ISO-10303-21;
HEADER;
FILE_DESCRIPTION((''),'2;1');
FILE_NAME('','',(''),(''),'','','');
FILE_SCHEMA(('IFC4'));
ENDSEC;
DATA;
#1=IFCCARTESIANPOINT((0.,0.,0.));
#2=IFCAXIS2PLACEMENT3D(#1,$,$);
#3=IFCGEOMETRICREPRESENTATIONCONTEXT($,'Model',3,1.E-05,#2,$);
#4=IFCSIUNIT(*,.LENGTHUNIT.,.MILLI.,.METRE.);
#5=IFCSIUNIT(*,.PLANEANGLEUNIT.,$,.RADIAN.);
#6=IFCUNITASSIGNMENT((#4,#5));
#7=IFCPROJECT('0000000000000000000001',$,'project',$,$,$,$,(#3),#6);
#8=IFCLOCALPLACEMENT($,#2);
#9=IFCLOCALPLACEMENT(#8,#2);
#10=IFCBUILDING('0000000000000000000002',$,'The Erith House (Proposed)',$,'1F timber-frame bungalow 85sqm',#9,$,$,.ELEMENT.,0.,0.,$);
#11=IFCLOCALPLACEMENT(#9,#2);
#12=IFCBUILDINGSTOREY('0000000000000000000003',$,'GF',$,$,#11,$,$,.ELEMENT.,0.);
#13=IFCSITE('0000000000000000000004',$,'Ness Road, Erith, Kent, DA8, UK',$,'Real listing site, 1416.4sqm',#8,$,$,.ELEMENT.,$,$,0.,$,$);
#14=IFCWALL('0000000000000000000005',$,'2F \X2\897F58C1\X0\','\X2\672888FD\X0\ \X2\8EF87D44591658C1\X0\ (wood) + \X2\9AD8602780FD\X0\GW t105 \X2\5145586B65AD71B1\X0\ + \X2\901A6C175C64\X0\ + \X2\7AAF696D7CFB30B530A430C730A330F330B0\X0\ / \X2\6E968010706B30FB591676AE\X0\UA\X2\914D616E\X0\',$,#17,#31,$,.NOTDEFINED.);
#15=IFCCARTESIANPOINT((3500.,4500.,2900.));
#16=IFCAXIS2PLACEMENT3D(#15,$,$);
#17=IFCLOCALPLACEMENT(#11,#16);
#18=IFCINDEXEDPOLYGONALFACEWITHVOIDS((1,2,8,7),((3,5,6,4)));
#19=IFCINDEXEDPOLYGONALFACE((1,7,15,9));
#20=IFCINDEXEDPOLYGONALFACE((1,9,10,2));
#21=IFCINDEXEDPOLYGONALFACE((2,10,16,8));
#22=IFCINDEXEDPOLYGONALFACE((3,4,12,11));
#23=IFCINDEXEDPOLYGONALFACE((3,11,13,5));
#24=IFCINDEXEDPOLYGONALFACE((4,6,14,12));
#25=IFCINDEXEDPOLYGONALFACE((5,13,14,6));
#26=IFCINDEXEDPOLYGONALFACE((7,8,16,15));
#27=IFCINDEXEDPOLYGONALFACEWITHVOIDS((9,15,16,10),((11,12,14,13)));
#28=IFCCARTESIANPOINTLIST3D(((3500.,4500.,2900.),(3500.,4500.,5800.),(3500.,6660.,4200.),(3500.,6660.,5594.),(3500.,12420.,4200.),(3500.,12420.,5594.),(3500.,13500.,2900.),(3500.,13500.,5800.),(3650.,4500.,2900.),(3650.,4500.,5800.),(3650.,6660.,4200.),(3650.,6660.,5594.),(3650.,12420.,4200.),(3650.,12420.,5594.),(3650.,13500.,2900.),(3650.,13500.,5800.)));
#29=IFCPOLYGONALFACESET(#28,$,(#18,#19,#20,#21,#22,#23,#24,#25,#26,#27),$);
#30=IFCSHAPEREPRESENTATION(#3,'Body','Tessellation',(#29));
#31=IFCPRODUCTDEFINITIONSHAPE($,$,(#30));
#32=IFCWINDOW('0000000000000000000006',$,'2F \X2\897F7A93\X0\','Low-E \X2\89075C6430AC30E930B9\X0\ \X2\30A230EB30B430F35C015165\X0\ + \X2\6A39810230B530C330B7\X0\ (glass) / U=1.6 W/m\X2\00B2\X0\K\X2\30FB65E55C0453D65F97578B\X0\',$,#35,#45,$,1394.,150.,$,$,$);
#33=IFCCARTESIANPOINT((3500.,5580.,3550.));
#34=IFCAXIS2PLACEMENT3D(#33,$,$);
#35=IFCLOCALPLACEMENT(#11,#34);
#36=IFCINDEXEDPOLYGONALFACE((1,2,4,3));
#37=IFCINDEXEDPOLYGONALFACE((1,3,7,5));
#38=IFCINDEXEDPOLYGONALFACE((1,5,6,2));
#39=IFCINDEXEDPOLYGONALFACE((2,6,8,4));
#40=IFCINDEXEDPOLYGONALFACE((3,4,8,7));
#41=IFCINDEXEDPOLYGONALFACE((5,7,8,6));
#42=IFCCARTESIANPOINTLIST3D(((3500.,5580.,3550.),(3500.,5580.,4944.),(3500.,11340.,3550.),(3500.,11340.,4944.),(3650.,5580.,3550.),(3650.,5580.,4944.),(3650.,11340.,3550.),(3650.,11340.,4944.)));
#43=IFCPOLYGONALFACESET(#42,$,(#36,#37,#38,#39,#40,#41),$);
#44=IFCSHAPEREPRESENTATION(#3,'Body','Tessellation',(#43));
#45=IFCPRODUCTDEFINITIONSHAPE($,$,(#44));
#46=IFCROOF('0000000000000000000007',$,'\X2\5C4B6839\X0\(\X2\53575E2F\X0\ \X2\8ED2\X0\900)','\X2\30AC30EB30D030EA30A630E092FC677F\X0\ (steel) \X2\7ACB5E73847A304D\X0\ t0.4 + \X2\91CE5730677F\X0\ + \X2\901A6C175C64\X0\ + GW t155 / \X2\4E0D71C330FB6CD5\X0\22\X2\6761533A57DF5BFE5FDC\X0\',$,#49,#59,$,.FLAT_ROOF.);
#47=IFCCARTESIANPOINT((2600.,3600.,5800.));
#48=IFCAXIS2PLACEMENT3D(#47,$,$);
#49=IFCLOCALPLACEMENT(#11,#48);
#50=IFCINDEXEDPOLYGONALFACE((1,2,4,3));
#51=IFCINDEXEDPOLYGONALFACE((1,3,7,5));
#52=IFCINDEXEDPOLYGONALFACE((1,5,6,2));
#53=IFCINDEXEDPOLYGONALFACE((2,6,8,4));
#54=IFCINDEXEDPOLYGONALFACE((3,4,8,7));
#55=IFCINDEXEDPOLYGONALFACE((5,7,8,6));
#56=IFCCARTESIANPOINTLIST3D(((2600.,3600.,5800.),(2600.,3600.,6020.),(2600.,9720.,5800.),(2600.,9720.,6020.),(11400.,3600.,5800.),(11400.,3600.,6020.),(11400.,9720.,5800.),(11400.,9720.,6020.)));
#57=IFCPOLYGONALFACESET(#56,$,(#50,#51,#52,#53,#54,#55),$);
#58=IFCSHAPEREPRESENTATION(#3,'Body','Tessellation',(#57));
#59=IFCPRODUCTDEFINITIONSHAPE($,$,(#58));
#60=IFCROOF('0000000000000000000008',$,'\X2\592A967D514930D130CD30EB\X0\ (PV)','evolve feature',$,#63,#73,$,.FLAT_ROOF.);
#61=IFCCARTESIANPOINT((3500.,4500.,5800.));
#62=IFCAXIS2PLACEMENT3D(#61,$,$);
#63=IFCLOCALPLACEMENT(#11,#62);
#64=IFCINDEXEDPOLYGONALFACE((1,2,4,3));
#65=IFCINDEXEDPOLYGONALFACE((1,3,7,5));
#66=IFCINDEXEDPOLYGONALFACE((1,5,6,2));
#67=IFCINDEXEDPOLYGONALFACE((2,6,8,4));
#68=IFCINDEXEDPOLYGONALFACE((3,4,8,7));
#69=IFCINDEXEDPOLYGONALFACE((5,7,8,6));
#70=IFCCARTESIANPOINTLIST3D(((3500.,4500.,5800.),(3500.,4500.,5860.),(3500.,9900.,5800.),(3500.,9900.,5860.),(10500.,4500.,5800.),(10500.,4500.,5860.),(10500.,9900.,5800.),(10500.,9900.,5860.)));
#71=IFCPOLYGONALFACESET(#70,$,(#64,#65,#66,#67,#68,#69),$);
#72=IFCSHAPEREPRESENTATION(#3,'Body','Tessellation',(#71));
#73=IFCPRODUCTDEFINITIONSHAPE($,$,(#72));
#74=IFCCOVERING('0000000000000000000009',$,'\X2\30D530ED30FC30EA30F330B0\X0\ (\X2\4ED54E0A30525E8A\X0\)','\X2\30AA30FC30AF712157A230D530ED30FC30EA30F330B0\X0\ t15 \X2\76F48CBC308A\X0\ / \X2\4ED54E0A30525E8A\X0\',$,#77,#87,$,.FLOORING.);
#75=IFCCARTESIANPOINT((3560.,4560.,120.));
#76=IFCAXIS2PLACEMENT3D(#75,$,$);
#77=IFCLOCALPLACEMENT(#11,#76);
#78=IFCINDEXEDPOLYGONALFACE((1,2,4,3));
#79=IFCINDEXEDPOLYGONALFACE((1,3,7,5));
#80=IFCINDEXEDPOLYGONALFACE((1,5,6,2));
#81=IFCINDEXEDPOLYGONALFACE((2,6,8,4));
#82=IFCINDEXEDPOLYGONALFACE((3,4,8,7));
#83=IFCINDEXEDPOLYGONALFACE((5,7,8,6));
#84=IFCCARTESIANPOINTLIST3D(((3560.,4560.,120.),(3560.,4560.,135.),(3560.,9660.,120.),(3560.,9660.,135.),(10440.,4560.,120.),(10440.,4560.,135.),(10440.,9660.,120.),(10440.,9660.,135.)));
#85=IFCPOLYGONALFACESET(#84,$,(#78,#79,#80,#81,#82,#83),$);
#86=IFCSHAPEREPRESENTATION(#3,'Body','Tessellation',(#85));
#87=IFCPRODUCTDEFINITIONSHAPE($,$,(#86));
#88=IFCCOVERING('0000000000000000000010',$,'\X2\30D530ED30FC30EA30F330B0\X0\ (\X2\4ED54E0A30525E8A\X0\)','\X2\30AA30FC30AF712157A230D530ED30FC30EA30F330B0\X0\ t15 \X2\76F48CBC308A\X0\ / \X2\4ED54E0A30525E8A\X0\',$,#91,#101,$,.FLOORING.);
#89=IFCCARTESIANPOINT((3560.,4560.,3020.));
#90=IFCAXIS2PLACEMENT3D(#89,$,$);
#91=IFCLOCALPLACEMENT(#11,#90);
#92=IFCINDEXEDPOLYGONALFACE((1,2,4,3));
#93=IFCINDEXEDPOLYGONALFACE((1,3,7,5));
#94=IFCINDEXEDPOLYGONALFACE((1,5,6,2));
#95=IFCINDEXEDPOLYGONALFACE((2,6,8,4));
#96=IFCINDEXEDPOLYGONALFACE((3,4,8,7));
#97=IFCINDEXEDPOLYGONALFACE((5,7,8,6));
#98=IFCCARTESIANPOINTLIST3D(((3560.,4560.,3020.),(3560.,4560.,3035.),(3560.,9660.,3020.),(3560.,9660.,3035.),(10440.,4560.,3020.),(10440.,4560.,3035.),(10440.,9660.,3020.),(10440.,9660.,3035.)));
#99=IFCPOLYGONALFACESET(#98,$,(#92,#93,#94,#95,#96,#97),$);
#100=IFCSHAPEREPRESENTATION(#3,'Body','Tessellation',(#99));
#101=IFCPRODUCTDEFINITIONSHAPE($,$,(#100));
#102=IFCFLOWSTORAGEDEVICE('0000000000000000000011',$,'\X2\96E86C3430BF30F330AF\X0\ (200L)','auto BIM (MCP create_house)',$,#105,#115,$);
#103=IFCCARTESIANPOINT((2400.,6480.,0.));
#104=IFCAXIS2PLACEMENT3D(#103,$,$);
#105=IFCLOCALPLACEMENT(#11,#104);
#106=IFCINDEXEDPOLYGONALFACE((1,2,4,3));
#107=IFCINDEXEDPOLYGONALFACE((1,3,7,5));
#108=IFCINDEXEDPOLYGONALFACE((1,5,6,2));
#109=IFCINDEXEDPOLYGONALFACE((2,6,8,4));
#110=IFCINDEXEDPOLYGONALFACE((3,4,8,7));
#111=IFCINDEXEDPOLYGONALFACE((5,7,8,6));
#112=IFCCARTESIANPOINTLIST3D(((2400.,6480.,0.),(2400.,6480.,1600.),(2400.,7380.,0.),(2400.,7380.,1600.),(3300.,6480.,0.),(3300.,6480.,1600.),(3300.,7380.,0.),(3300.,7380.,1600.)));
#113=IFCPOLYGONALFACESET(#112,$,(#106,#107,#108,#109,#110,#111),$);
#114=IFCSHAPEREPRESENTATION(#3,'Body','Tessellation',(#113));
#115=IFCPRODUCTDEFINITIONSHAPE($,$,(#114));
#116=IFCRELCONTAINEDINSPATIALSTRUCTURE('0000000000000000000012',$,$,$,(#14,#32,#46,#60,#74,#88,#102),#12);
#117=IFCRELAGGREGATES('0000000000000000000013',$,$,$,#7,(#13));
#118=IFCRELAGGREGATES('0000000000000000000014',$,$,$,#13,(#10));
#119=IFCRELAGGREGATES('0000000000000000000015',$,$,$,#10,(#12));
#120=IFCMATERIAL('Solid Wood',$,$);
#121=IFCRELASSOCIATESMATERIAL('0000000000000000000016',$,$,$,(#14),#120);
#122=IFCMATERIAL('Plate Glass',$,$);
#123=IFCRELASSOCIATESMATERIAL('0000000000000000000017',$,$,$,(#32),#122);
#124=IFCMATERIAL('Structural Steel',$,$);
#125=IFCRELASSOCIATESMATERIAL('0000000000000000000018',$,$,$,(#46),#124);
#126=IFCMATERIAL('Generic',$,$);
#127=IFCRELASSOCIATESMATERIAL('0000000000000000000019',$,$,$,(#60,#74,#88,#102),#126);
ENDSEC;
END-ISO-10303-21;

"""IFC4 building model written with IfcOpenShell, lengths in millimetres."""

from ifc_helpers import new_model, si_unit, frame, frame_2d, origin, place, context, project, spatial, rectangle, extrude, material, element, fill, save


model = new_model("IFC4")

# Units and contexts
model_context = context("Model", 3, precision=1e-05, world=origin())
ifc_project = project(units=[si_unit("LENGTHUNIT", "METRE", prefix="MILLI"), si_unit("PLANEANGLEUNIT", "RADIAN")], contexts=[model_context])

# Site, building, storey
site_placement = place(None, origin())
site = spatial("IfcSite", under=ifc_project, at=site_placement, Name="Ness Road, Erith, Kent, DA8, UK", ObjectType="Real listing site, 1416.4sqm", CompositionType="ELEMENT", RefElevation=0.0)
building_placement = place(site_placement, origin())
building = spatial("IfcBuilding", under=site, at=building_placement, Name="The Erith House (Proposed)", ObjectType="1F timber-frame bungalow 85sqm", CompositionType="ELEMENT", ElevationOfRefHeight=0.0, ElevationOfTerrain=0.0)
storey_placement = place(building_placement, origin())
storey = spatial("IfcBuildingStorey", under=building, at=storey_placement, Name="GF", CompositionType="ELEMENT", Elevation=0.0)

# Shared definitions
ifc_material_1 = material(Name="Solid Wood")
ifc_material_2 = material(Name="Generic")

# Shared definitions
ifc_material_3 = material(Name="Plate Glass")

# Wall, opening, window
wall_1_placement = place(storey_placement, frame((3500.0, 4500.0, 2900.0)))
wall_1 = element("IfcWall", 1, at=wall_1_placement, inside=storey, material=ifc_material_1, Name="2F 西壁", Description="木製 軸組外壁 (wood) + 高性能GW t105 充填断熱 + 通気層 + 窯業系サイディング / 準耐火・外皮UA配慮", PredefinedType="NOTDEFINED", context=model_context, shape_type="SweptSolid", body=[
    extrude(rectangle(XDim=150.0, YDim=9000.0, at=frame_2d((75.0, 4500.0))), frame((3500.0, 4500.0, 2900.0)), (0.0, 0.0, 1.0), 2900.0),
])
opening_1_placement = place(storey_placement, frame((3500.0, 5580.0, 3550.0)))
opening_1 = element("IfcOpeningElement", 2, at=opening_1_placement, cuts=wall_1, PredefinedType="NOTDEFINED", context=model_context, shape_type="SweptSolid", body=[
    extrude(rectangle(XDim=150.0, YDim=5760.0, at=frame_2d((75.0, 2880.0))), frame((3500.0, 5580.0, 3550.0)), (0.0, 0.0, 1.0), 1394.0),
])
window_1_placement = place(storey_placement, frame((3500.0, 5580.0, 3550.0)))
window_1 = element("IfcWindow", 3, at=window_1_placement, inside=storey, material=ifc_material_3, Name="2F 西窓", Description="Low-E 複層ガラス アルゴン封入 + 樹脂サッシ (glass) / U=1.6 W/m²K・日射取得型", OverallHeight=1394.0, OverallWidth=150.0, context=model_context, shape_type="SweptSolid", body=[
    extrude(rectangle(XDim=150.0, YDim=5760.0, at=frame_2d((75.0, 2880.0))), frame((3500.0, 5580.0, 3550.0)), (0.0, 0.0, 1.0), 1394.0),
])
fill(opening_1, window_1)

# Roofs
ifc_material_4 = material(Name="Structural Steel")
for number, where, name in (
    (4, (2600.0, 3600.0, 5800.0), "屋根(南帯 軒900)"),
):
    element("IfcRoof", number, at=place(storey_placement, frame(where)), inside=storey, material=ifc_material_4, Name=name, Description="ガルバリウム鋼板 (steel) 立平葺き t0.4 + 野地板 + 通気層 + GW t155 / 不燃・法22条区域対応", PredefinedType="FLAT_ROOF", context=model_context, shape_type="SweptSolid", body=[
        extrude(rectangle(XDim=8800.0, YDim=6120.0, at=frame_2d((4400.0, 3060.0))), frame((2600.0, 3600.0, 5800.0)), (0.0, 0.0, 1.0), 220.0),
    ])
roof_placement = place(storey_placement, frame((3500.0, 4500.0, 5800.0)))
element("IfcRoof", 5, at=roof_placement, inside=storey, material=ifc_material_2, Name="太陽光パネル (PV)", Description="evolve feature", PredefinedType="FLAT_ROOF", context=model_context, shape_type="SweptSolid", body=[
    extrude(rectangle(XDim=7000.0, YDim=5400.0, at=frame_2d((3500.0, 2700.0))), frame((3500.0, 4500.0, 5800.0)), (0.0, 0.0, 1.0), 60.0),
])

# Coverings
covering_1_placement = place(storey_placement, frame((3560.0, 4560.0, 120.0)))
element("IfcCovering", 6, at=covering_1_placement, inside=storey, material=ifc_material_2, Name="フローリング (仕上げ床)", Description="オーク無垢フローリング t15 直貼り / 仕上げ床", PredefinedType="FLOORING", context=model_context, shape_type="SweptSolid", body=[
    extrude(rectangle(XDim=6880.0, YDim=5100.0, at=frame_2d((3440.0, 2550.0))), frame((3560.0, 4560.0, 120.0)), (0.0, 0.0, 1.0), 15.0),
])
covering_2_placement = place(storey_placement, frame((3560.0, 4560.0, 3020.0)))
element("IfcCovering", 7, at=covering_2_placement, inside=storey, material=ifc_material_2, Name="フローリング (仕上げ床)", Description="オーク無垢フローリング t15 直貼り / 仕上げ床", PredefinedType="FLOORING", context=model_context, shape_type="SweptSolid", body=[
    extrude(rectangle(XDim=6880.0, YDim=5100.0, at=frame_2d((3440.0, 2550.0))), frame((3560.0, 4560.0, 3020.0)), (0.0, 0.0, 1.0), 15.0),
])

# Flow storage device
flow_storage_device_placement = place(storey_placement, frame((2400.0, 6480.0, 0.0)))
element("IfcFlowStorageDevice", 8, at=flow_storage_device_placement, inside=storey, material=ifc_material_2, Name="雨水タンク (200L)", Description="auto BIM (MCP create_house)", context=model_context, shape_type="SweptSolid", body=[
    extrude(rectangle(XDim=900.0, YDim=900.0, at=frame_2d((450.0, 450.0))), frame((2400.0, 6480.0, 0.0)), (0.0, 0.0, 1.0), 1600.0),
])

save(model, "model.ifc")
